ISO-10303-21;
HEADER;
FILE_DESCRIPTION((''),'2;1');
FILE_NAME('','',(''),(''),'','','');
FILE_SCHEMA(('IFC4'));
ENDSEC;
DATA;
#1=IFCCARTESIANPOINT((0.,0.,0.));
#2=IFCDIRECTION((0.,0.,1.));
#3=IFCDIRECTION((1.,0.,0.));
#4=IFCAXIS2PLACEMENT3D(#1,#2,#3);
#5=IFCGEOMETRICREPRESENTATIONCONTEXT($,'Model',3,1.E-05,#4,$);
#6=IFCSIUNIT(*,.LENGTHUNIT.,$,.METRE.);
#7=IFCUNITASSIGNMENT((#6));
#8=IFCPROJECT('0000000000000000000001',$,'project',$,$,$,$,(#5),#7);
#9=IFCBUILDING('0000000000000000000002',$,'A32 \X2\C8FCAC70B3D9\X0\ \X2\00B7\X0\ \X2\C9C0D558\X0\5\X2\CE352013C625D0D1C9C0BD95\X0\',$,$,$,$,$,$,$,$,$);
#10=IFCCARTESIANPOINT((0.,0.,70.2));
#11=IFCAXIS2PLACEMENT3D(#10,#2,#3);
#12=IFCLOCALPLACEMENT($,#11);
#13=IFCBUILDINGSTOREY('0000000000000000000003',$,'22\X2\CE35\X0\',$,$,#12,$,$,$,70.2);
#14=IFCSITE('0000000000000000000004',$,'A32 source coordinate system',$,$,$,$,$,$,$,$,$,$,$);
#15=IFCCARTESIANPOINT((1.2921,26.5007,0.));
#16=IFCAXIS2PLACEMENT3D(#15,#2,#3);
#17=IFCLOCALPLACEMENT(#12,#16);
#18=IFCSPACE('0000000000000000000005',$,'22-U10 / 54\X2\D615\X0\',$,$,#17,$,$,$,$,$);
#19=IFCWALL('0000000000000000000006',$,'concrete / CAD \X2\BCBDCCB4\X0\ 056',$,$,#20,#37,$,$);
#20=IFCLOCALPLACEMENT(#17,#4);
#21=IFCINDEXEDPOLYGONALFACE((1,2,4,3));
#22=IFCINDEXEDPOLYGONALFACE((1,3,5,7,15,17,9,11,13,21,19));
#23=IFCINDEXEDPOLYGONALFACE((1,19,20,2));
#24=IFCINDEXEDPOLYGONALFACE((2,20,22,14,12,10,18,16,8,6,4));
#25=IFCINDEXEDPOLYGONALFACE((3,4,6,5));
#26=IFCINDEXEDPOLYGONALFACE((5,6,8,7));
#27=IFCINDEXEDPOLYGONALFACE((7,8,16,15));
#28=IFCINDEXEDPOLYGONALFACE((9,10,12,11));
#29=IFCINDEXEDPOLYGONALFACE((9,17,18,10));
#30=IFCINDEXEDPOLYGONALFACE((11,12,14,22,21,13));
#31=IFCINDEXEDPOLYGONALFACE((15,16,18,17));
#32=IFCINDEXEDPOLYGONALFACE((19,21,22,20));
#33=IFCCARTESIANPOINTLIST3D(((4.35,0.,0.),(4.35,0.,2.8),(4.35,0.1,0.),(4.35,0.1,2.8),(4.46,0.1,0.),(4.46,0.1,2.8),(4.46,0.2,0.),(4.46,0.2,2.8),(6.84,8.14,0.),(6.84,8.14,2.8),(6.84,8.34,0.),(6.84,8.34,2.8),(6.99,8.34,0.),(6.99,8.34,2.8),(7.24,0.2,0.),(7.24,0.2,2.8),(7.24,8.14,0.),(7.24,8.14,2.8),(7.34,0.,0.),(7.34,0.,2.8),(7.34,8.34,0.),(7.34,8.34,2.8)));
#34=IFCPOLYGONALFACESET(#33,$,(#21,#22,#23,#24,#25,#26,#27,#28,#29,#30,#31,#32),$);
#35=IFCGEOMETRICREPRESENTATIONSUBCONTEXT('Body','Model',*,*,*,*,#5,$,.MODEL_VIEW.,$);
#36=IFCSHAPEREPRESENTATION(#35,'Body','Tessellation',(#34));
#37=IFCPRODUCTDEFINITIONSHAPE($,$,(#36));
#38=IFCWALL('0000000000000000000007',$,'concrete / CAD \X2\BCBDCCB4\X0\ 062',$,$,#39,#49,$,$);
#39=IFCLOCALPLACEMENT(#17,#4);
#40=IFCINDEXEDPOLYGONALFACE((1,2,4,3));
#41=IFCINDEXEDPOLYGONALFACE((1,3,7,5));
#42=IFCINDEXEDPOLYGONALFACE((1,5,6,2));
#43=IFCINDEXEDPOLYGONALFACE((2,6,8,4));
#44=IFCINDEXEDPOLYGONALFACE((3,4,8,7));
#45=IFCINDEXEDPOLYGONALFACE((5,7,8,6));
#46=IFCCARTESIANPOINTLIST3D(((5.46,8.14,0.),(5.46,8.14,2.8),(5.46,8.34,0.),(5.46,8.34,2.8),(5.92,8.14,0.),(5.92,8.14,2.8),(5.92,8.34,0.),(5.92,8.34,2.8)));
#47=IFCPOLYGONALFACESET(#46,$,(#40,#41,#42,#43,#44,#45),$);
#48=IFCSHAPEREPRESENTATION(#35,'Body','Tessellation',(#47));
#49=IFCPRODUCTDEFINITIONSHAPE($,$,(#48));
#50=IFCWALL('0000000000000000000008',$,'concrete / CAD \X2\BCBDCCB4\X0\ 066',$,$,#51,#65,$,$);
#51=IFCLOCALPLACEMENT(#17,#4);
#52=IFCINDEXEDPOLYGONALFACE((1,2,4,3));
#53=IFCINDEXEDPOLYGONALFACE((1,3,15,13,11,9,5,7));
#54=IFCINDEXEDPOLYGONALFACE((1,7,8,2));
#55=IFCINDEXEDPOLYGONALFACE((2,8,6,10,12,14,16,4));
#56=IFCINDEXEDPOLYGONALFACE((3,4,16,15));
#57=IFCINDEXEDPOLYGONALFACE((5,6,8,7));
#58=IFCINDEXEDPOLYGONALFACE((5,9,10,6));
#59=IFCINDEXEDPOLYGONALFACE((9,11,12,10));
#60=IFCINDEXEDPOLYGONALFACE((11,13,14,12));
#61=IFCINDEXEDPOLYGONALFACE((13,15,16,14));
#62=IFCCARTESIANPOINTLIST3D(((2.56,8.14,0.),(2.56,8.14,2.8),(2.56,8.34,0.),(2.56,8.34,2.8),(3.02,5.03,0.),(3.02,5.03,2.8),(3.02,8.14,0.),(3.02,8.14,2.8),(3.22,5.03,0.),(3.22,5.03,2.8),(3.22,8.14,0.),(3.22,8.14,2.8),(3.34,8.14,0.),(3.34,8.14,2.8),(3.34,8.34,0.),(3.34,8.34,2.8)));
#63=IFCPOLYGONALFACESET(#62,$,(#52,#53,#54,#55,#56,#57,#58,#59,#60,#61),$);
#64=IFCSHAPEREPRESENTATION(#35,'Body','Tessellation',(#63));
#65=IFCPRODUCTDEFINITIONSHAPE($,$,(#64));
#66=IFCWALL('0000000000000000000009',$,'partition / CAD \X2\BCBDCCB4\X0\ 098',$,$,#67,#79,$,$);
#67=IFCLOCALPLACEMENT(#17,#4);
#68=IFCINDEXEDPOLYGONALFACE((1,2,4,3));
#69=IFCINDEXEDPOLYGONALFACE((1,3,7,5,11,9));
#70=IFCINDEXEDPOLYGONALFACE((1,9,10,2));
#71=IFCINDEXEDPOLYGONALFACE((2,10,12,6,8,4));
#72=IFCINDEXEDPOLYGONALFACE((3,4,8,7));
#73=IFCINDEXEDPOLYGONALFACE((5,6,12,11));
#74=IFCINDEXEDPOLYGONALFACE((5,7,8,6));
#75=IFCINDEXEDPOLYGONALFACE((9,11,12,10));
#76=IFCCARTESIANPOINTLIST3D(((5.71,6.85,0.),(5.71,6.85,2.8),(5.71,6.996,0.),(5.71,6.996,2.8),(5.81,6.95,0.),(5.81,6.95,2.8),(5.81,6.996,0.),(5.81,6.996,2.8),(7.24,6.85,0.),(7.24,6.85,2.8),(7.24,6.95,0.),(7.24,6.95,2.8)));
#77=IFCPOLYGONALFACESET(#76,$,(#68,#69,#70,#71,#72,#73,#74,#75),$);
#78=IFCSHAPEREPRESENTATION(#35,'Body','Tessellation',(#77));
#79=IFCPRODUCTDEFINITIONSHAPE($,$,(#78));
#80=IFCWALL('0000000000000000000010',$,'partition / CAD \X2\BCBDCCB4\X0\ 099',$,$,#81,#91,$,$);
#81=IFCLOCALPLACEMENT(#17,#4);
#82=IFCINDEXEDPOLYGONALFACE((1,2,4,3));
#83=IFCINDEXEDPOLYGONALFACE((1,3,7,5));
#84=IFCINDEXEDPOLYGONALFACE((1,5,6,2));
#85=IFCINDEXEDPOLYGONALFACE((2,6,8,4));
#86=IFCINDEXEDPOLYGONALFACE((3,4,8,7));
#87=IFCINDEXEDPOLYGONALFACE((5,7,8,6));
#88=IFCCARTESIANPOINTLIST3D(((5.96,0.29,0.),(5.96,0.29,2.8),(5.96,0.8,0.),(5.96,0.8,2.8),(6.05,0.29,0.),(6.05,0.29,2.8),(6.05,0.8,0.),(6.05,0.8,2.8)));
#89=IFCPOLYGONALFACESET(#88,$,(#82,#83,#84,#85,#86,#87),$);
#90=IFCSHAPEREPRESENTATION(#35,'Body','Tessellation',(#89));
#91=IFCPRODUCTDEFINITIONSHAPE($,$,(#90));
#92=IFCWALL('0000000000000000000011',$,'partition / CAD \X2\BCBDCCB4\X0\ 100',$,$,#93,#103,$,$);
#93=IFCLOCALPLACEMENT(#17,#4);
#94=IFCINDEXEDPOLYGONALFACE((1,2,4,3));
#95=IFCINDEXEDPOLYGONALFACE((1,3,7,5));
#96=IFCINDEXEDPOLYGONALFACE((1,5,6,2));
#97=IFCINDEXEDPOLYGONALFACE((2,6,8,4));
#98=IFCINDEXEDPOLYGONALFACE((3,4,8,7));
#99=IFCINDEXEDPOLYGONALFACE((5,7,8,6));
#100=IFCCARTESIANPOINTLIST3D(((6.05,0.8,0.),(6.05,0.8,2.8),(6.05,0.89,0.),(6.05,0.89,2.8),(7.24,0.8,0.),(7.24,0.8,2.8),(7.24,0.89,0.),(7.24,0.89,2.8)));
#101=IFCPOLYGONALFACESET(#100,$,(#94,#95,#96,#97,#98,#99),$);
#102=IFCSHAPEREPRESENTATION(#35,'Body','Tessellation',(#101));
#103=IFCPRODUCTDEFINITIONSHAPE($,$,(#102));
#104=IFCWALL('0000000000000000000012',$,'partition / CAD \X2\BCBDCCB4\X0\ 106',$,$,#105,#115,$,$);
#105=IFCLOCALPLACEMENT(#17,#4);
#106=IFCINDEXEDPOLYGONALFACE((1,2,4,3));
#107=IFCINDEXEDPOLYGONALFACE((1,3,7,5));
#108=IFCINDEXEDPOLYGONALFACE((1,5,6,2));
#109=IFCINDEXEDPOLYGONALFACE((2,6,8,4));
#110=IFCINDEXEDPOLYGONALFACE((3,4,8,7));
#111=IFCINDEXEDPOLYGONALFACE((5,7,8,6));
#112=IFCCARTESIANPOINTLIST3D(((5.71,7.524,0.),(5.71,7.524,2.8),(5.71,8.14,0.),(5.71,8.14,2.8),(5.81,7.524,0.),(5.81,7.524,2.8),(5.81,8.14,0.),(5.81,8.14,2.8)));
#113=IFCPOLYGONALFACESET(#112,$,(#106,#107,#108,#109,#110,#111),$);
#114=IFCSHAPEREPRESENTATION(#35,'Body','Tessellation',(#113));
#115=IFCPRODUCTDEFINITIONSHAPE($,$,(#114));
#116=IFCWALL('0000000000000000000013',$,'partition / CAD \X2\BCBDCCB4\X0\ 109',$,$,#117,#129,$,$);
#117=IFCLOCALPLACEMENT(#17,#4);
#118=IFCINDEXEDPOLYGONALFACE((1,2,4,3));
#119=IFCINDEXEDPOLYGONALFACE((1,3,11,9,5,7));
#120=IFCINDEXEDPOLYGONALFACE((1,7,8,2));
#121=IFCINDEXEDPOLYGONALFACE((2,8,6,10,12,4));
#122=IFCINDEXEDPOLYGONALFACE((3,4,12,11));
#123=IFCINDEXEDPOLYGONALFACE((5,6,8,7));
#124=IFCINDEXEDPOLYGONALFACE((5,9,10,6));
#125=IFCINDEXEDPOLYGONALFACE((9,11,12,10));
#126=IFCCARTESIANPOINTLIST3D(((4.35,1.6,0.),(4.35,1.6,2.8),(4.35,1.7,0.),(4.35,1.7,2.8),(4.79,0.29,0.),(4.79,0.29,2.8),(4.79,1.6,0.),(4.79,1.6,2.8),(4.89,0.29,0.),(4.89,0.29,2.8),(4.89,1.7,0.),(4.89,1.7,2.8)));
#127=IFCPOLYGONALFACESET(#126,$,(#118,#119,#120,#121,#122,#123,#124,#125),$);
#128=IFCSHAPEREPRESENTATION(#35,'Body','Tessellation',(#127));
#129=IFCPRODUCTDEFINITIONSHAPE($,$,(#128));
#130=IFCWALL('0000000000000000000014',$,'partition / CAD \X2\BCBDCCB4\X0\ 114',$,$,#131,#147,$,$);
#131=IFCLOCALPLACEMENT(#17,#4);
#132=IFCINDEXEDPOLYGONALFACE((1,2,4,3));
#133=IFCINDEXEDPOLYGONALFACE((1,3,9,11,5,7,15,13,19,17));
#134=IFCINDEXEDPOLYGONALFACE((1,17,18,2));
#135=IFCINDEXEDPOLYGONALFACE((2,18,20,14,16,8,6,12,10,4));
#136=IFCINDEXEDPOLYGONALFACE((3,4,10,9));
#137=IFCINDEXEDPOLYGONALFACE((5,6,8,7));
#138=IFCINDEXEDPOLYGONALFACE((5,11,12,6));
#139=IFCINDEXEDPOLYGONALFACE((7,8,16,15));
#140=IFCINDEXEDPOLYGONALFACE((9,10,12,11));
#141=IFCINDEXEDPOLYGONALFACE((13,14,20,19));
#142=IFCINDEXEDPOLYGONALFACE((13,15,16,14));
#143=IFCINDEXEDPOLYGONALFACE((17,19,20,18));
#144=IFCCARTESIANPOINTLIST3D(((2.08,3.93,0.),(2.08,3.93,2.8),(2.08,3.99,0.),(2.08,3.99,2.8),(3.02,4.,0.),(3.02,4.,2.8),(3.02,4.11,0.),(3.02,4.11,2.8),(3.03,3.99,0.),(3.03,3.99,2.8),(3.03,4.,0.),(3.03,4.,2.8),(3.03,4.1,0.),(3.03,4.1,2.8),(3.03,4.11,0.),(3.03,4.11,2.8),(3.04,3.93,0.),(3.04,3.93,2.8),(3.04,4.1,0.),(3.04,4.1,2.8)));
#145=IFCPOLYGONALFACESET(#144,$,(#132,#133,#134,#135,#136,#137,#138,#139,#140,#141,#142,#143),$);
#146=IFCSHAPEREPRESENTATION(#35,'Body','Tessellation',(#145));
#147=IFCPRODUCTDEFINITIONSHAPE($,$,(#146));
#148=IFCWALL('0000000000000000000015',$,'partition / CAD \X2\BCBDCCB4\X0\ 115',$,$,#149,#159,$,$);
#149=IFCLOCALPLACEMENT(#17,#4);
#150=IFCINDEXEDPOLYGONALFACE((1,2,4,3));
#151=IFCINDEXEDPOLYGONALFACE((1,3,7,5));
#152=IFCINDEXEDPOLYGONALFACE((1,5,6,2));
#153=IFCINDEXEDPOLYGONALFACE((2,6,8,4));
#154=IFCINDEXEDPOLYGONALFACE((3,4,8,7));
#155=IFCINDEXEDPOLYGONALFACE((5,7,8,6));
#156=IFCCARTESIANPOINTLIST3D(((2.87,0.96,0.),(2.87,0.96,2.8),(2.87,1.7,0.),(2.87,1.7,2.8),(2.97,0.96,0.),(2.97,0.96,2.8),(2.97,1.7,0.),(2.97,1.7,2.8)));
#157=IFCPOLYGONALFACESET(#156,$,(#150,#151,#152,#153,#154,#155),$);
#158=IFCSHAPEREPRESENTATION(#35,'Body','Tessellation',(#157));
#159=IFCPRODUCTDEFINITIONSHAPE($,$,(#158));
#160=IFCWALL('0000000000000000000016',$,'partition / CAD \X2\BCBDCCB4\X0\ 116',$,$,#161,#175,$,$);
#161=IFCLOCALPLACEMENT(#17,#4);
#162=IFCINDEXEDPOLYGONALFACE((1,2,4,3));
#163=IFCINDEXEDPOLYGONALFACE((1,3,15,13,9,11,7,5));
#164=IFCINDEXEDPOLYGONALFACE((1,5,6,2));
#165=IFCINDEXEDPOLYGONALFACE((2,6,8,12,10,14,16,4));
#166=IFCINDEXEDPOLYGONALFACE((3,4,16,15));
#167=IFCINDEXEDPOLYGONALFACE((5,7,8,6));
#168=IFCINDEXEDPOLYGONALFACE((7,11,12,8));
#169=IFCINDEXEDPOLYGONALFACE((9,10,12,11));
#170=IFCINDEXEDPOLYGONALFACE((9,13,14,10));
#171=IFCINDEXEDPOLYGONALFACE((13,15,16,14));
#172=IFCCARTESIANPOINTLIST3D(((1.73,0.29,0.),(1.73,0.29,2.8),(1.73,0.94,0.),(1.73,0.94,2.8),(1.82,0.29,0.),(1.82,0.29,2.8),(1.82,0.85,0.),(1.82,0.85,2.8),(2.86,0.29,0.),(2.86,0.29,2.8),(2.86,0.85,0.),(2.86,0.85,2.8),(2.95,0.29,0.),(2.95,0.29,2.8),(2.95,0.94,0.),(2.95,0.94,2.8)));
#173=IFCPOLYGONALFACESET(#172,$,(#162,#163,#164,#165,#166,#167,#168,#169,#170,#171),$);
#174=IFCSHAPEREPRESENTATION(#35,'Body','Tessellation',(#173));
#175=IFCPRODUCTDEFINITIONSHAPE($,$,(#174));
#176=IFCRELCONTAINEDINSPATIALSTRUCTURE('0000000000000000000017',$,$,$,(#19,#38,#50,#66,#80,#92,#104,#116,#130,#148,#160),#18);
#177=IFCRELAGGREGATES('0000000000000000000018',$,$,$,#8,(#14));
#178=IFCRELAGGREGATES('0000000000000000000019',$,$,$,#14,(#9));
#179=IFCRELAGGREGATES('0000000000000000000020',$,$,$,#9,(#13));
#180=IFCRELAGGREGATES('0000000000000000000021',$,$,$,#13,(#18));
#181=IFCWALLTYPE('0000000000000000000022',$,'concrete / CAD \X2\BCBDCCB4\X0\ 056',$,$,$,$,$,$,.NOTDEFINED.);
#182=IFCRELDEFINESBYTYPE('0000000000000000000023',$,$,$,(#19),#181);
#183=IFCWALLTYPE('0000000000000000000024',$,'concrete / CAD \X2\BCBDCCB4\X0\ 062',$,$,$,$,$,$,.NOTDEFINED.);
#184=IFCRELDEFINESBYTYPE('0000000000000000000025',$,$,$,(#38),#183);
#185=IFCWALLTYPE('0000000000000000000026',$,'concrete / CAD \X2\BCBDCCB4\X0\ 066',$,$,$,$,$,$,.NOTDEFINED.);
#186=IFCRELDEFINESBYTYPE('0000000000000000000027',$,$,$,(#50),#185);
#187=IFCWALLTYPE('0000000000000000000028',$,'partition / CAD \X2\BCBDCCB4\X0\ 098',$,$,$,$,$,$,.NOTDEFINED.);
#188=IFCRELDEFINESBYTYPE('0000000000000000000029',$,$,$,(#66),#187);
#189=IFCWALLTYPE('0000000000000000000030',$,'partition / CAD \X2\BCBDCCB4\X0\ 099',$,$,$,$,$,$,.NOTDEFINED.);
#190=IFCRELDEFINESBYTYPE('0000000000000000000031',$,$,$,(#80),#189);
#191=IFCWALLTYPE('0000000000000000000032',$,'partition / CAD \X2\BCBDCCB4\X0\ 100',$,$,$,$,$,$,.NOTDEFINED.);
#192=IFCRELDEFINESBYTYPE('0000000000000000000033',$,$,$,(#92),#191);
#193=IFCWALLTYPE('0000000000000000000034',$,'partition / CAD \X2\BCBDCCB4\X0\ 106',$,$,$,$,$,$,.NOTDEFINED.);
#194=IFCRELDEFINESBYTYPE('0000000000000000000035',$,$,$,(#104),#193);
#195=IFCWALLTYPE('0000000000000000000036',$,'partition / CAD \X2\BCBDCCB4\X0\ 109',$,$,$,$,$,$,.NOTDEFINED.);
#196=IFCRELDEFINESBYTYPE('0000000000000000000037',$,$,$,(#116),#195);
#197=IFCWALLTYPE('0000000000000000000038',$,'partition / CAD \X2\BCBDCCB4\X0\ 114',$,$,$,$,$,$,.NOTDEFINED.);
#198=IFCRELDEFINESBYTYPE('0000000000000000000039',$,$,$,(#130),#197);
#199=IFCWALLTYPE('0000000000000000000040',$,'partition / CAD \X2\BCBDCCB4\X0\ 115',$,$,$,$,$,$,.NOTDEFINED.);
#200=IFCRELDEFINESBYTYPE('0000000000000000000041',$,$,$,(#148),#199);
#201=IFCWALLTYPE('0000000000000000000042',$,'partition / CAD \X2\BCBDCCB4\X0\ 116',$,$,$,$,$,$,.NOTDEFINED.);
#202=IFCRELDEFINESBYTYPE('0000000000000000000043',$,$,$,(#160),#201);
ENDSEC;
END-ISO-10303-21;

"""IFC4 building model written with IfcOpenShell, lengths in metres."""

from ifc_helpers import new_model, si_unit, frame, origin, origin_with_axes, place, context, subcontext, project, spatial, polyline, outline, extrude, source, transform, mapped, type_object, type_shapes, element, save


model = new_model("IFC4")

# Units and contexts
model_context = context("Model", 3, precision=1e-05, world=origin_with_axes())
body_context = subcontext(model_context, "Body", "Model", "MODEL_VIEW")
ifc_project = project(units=[si_unit("LENGTHUNIT", "METRE")], contexts=[model_context])

# Site, building, storey, space
site = spatial("IfcSite", under=ifc_project, Name="A32 source coordinate system")
building = spatial("IfcBuilding", under=site, Name="A32 주거동 · 지하5층–옥탑지붕")
storey_placement = place(None, frame((0.0, 0.0, 70.2), z_axis=(0.0, 0.0, 1.0), x_axis=(1.0, 0.0, 0.0)))
storey = spatial("IfcBuildingStorey", under=building, at=storey_placement, Name="22층", Elevation=70.2)
space_placement = place(storey_placement, frame((1.2921, 26.5007, 0.0), z_axis=(0.0, 0.0, 1.0), x_axis=(1.0, 0.0, 0.0)))
space = spatial("IfcSpace", under=storey, at=space_placement, Name="22-U10 / 54형")

# Walls
wall_type_1 = type_object("IfcWallType", Name="concrete / CAD 벽체 056", PredefinedType="NOTDEFINED")
shared_shape_1 = source(origin(), body_context, "Body", "SweptSolid", [
    extrude(outline(polyline([(7.24, 0.2), (7.24, 8.14), (6.84, 8.14), (6.84, 8.34), (6.99, 8.34), (6.99, 8.34), (7.34, 8.34), (7.34, 0.0), (4.35, 0.0), (4.35, 0.1), (4.46, 0.1), (4.46, 0.2), (7.24, 0.2)])), origin(), (0.0, 0.0, 1.0), 2.8),
])
type_shapes(wall_type_1, [shared_shape_1])
wall_1_placement = place(space_placement, origin_with_axes())
element("IfcWall", 1, at=wall_1_placement, inside=space, type_object=wall_type_1, Name="concrete / CAD 벽체 056", context=body_context, shape_type="MappedRepresentation", body=[
    mapped(shared_shape_1, transform((0.0, 0.0, 0.0), scale=1.0)),
])
wall_type_2 = type_object("IfcWallType", Name="concrete / CAD 벽체 062", PredefinedType="NOTDEFINED")
shared_shape_2 = source(origin(), body_context, "Body", "SweptSolid", [
    extrude(outline(polyline([(5.46, 8.14), (5.46, 8.34), (5.92, 8.34), (5.92, 8.14), (5.46, 8.14)])), origin(), (0.0, 0.0, 1.0), 2.8),
])
type_shapes(wall_type_2, [shared_shape_2])
wall_2_placement = place(space_placement, origin_with_axes())
element("IfcWall", 2, at=wall_2_placement, inside=space, type_object=wall_type_2, Name="concrete / CAD 벽체 062", context=body_context, shape_type="MappedRepresentation", body=[
    mapped(shared_shape_2, transform((0.0, 0.0, 0.0), scale=1.0)),
])
wall_type_3 = type_object("IfcWallType", Name="concrete / CAD 벽체 066", PredefinedType="NOTDEFINED")
shared_shape_3 = source(origin(), body_context, "Body", "SweptSolid", [
    extrude(outline(polyline([(3.22, 8.14), (3.22, 5.03), (3.02, 5.03), (3.02, 8.14), (2.56, 8.14), (2.56, 8.34), (3.34, 8.34), (3.34, 8.14), (3.22, 8.14)])), origin(), (0.0, 0.0, 1.0), 2.8),
])
type_shapes(wall_type_3, [shared_shape_3])
wall_3_placement = place(space_placement, origin_with_axes())
element("IfcWall", 3, at=wall_3_placement, inside=space, type_object=wall_type_3, Name="concrete / CAD 벽체 066", context=body_context, shape_type="MappedRepresentation", body=[
    mapped(shared_shape_3, transform((0.0, 0.0, 0.0), scale=1.0)),
])
wall_type_4 = type_object("IfcWallType", Name="partition / CAD 벽체 098", PredefinedType="NOTDEFINED")
shared_shape_4 = source(origin(), body_context, "Body", "SweptSolid", [
    extrude(outline(polyline([(5.71, 6.996), (5.81, 6.996), (5.81, 6.95), (7.24, 6.95), (7.24, 6.85), (5.71, 6.85), (5.71, 6.996)])), origin(), (0.0, 0.0, 1.0), 2.8),
])
type_shapes(wall_type_4, [shared_shape_4])
wall_4_placement = place(space_placement, origin_with_axes())
element("IfcWall", 4, at=wall_4_placement, inside=space, type_object=wall_type_4, Name="partition / CAD 벽체 098", context=body_context, shape_type="MappedRepresentation", body=[
    mapped(shared_shape_4, transform((0.0, 0.0, 0.0), scale=1.0)),
])
wall_type_5 = type_object("IfcWallType", Name="partition / CAD 벽체 099", PredefinedType="NOTDEFINED")
shared_shape_5 = source(origin(), body_context, "Body", "SweptSolid", [
    extrude(outline(polyline([(6.05, 0.8), (6.05, 0.29), (5.96, 0.29), (5.96, 0.8), (6.05, 0.8)])), origin(), (0.0, 0.0, 1.0), 2.8),
])
type_shapes(wall_type_5, [shared_shape_5])
wall_5_placement = place(space_placement, origin_with_axes())
element("IfcWall", 5, at=wall_5_placement, inside=space, type_object=wall_type_5, Name="partition / CAD 벽체 099", context=body_context, shape_type="MappedRepresentation", body=[
    mapped(shared_shape_5, transform((0.0, 0.0, 0.0), scale=1.0)),
])
wall_type_6 = type_object("IfcWallType", Name="partition / CAD 벽체 100", PredefinedType="NOTDEFINED")
shared_shape_6 = source(origin(), body_context, "Body", "SweptSolid", [
    extrude(outline(polyline([(7.24, 0.8), (6.05, 0.8), (6.05, 0.89), (7.24, 0.89), (7.24, 0.8)])), origin(), (0.0, 0.0, 1.0), 2.8),
])
type_shapes(wall_type_6, [shared_shape_6])
wall_6_placement = place(space_placement, origin_with_axes())
element("IfcWall", 6, at=wall_6_placement, inside=space, type_object=wall_type_6, Name="partition / CAD 벽체 100", context=body_context, shape_type="MappedRepresentation", body=[
    mapped(shared_shape_6, transform((0.0, 0.0, 0.0), scale=1.0)),
])
wall_type_7 = type_object("IfcWallType", Name="partition / CAD 벽체 106", PredefinedType="NOTDEFINED")
shared_shape_7 = source(origin(), body_context, "Body", "SweptSolid", [
    extrude(outline(polyline([(5.71, 8.14), (5.81, 8.14), (5.81, 7.524), (5.71, 7.524), (5.71, 8.14)])), origin(), (0.0, 0.0, 1.0), 2.8),
])
type_shapes(wall_type_7, [shared_shape_7])
wall_7_placement = place(space_placement, origin_with_axes())
element("IfcWall", 7, at=wall_7_placement, inside=space, type_object=wall_type_7, Name="partition / CAD 벽체 106", context=body_context, shape_type="MappedRepresentation", body=[
    mapped(shared_shape_7, transform((0.0, 0.0, 0.0), scale=1.0)),
])
wall_type_8 = type_object("IfcWallType", Name="partition / CAD 벽체 109", PredefinedType="NOTDEFINED")
shared_shape_8 = source(origin(), body_context, "Body", "SweptSolid", [
    extrude(outline(polyline([(4.79, 1.6), (4.35, 1.6), (4.35, 1.7), (4.89, 1.7), (4.89, 0.29), (4.79, 0.29), (4.79, 1.6)])), origin(), (0.0, 0.0, 1.0), 2.8),
])
type_shapes(wall_type_8, [shared_shape_8])
wall_8_placement = place(space_placement, origin_with_axes())
element("IfcWall", 8, at=wall_8_placement, inside=space, type_object=wall_type_8, Name="partition / CAD 벽체 109", context=body_context, shape_type="MappedRepresentation", body=[
    mapped(shared_shape_8, transform((0.0, 0.0, 0.0), scale=1.0)),
])
wall_type_9 = type_object("IfcWallType", Name="partition / CAD 벽체 114", PredefinedType="NOTDEFINED")
shared_shape_9 = source(origin(), body_context, "Body", "SweptSolid", [
    extrude(outline(polyline([(2.08, 3.99), (3.03, 3.99), (3.03, 4.0), (3.02, 4.0), (3.02, 4.11), (3.03, 4.11), (3.03, 4.1), (3.04, 4.1), (3.04, 3.93), (2.08, 3.93), (2.08, 3.99)])), origin(), (0.0, 0.0, 1.0), 2.8),
])
type_shapes(wall_type_9, [shared_shape_9])
wall_9_placement = place(space_placement, origin_with_axes())
element("IfcWall", 9, at=wall_9_placement, inside=space, type_object=wall_type_9, Name="partition / CAD 벽체 114", context=body_context, shape_type="MappedRepresentation", body=[
    mapped(shared_shape_9, transform((0.0, 0.0, 0.0), scale=1.0)),
])
wall_type_10 = type_object("IfcWallType", Name="partition / CAD 벽체 115", PredefinedType="NOTDEFINED")
shared_shape_10 = source(origin(), body_context, "Body", "SweptSolid", [
    extrude(outline(polyline([(2.87, 1.7), (2.97, 1.7), (2.97, 0.96), (2.87, 0.96), (2.87, 1.7)])), origin(), (0.0, 0.0, 1.0), 2.8),
])
type_shapes(wall_type_10, [shared_shape_10])
wall_10_placement = place(space_placement, origin_with_axes())
element("IfcWall", 10, at=wall_10_placement, inside=space, type_object=wall_type_10, Name="partition / CAD 벽체 115", context=body_context, shape_type="MappedRepresentation", body=[
    mapped(shared_shape_10, transform((0.0, 0.0, 0.0), scale=1.0)),
])
wall_type_11 = type_object("IfcWallType", Name="partition / CAD 벽체 116", PredefinedType="NOTDEFINED")
shared_shape_11 = source(origin(), body_context, "Body", "SweptSolid", [
    extrude(outline(polyline([(2.95, 0.29), (2.86, 0.29), (2.86, 0.85), (1.82, 0.85), (1.82, 0.29), (1.73, 0.29), (1.73, 0.94), (2.95, 0.94), (2.95, 0.29)])), origin(), (0.0, 0.0, 1.0), 2.8),
])
type_shapes(wall_type_11, [shared_shape_11])
wall_11_placement = place(space_placement, origin_with_axes())
element("IfcWall", 11, at=wall_11_placement, inside=space, type_object=wall_type_11, Name="partition / CAD 벽체 116", context=body_context, shape_type="MappedRepresentation", body=[
    mapped(shared_shape_11, transform((0.0, 0.0, 0.0), scale=1.0)),
])

save(model, "model.ifc")
